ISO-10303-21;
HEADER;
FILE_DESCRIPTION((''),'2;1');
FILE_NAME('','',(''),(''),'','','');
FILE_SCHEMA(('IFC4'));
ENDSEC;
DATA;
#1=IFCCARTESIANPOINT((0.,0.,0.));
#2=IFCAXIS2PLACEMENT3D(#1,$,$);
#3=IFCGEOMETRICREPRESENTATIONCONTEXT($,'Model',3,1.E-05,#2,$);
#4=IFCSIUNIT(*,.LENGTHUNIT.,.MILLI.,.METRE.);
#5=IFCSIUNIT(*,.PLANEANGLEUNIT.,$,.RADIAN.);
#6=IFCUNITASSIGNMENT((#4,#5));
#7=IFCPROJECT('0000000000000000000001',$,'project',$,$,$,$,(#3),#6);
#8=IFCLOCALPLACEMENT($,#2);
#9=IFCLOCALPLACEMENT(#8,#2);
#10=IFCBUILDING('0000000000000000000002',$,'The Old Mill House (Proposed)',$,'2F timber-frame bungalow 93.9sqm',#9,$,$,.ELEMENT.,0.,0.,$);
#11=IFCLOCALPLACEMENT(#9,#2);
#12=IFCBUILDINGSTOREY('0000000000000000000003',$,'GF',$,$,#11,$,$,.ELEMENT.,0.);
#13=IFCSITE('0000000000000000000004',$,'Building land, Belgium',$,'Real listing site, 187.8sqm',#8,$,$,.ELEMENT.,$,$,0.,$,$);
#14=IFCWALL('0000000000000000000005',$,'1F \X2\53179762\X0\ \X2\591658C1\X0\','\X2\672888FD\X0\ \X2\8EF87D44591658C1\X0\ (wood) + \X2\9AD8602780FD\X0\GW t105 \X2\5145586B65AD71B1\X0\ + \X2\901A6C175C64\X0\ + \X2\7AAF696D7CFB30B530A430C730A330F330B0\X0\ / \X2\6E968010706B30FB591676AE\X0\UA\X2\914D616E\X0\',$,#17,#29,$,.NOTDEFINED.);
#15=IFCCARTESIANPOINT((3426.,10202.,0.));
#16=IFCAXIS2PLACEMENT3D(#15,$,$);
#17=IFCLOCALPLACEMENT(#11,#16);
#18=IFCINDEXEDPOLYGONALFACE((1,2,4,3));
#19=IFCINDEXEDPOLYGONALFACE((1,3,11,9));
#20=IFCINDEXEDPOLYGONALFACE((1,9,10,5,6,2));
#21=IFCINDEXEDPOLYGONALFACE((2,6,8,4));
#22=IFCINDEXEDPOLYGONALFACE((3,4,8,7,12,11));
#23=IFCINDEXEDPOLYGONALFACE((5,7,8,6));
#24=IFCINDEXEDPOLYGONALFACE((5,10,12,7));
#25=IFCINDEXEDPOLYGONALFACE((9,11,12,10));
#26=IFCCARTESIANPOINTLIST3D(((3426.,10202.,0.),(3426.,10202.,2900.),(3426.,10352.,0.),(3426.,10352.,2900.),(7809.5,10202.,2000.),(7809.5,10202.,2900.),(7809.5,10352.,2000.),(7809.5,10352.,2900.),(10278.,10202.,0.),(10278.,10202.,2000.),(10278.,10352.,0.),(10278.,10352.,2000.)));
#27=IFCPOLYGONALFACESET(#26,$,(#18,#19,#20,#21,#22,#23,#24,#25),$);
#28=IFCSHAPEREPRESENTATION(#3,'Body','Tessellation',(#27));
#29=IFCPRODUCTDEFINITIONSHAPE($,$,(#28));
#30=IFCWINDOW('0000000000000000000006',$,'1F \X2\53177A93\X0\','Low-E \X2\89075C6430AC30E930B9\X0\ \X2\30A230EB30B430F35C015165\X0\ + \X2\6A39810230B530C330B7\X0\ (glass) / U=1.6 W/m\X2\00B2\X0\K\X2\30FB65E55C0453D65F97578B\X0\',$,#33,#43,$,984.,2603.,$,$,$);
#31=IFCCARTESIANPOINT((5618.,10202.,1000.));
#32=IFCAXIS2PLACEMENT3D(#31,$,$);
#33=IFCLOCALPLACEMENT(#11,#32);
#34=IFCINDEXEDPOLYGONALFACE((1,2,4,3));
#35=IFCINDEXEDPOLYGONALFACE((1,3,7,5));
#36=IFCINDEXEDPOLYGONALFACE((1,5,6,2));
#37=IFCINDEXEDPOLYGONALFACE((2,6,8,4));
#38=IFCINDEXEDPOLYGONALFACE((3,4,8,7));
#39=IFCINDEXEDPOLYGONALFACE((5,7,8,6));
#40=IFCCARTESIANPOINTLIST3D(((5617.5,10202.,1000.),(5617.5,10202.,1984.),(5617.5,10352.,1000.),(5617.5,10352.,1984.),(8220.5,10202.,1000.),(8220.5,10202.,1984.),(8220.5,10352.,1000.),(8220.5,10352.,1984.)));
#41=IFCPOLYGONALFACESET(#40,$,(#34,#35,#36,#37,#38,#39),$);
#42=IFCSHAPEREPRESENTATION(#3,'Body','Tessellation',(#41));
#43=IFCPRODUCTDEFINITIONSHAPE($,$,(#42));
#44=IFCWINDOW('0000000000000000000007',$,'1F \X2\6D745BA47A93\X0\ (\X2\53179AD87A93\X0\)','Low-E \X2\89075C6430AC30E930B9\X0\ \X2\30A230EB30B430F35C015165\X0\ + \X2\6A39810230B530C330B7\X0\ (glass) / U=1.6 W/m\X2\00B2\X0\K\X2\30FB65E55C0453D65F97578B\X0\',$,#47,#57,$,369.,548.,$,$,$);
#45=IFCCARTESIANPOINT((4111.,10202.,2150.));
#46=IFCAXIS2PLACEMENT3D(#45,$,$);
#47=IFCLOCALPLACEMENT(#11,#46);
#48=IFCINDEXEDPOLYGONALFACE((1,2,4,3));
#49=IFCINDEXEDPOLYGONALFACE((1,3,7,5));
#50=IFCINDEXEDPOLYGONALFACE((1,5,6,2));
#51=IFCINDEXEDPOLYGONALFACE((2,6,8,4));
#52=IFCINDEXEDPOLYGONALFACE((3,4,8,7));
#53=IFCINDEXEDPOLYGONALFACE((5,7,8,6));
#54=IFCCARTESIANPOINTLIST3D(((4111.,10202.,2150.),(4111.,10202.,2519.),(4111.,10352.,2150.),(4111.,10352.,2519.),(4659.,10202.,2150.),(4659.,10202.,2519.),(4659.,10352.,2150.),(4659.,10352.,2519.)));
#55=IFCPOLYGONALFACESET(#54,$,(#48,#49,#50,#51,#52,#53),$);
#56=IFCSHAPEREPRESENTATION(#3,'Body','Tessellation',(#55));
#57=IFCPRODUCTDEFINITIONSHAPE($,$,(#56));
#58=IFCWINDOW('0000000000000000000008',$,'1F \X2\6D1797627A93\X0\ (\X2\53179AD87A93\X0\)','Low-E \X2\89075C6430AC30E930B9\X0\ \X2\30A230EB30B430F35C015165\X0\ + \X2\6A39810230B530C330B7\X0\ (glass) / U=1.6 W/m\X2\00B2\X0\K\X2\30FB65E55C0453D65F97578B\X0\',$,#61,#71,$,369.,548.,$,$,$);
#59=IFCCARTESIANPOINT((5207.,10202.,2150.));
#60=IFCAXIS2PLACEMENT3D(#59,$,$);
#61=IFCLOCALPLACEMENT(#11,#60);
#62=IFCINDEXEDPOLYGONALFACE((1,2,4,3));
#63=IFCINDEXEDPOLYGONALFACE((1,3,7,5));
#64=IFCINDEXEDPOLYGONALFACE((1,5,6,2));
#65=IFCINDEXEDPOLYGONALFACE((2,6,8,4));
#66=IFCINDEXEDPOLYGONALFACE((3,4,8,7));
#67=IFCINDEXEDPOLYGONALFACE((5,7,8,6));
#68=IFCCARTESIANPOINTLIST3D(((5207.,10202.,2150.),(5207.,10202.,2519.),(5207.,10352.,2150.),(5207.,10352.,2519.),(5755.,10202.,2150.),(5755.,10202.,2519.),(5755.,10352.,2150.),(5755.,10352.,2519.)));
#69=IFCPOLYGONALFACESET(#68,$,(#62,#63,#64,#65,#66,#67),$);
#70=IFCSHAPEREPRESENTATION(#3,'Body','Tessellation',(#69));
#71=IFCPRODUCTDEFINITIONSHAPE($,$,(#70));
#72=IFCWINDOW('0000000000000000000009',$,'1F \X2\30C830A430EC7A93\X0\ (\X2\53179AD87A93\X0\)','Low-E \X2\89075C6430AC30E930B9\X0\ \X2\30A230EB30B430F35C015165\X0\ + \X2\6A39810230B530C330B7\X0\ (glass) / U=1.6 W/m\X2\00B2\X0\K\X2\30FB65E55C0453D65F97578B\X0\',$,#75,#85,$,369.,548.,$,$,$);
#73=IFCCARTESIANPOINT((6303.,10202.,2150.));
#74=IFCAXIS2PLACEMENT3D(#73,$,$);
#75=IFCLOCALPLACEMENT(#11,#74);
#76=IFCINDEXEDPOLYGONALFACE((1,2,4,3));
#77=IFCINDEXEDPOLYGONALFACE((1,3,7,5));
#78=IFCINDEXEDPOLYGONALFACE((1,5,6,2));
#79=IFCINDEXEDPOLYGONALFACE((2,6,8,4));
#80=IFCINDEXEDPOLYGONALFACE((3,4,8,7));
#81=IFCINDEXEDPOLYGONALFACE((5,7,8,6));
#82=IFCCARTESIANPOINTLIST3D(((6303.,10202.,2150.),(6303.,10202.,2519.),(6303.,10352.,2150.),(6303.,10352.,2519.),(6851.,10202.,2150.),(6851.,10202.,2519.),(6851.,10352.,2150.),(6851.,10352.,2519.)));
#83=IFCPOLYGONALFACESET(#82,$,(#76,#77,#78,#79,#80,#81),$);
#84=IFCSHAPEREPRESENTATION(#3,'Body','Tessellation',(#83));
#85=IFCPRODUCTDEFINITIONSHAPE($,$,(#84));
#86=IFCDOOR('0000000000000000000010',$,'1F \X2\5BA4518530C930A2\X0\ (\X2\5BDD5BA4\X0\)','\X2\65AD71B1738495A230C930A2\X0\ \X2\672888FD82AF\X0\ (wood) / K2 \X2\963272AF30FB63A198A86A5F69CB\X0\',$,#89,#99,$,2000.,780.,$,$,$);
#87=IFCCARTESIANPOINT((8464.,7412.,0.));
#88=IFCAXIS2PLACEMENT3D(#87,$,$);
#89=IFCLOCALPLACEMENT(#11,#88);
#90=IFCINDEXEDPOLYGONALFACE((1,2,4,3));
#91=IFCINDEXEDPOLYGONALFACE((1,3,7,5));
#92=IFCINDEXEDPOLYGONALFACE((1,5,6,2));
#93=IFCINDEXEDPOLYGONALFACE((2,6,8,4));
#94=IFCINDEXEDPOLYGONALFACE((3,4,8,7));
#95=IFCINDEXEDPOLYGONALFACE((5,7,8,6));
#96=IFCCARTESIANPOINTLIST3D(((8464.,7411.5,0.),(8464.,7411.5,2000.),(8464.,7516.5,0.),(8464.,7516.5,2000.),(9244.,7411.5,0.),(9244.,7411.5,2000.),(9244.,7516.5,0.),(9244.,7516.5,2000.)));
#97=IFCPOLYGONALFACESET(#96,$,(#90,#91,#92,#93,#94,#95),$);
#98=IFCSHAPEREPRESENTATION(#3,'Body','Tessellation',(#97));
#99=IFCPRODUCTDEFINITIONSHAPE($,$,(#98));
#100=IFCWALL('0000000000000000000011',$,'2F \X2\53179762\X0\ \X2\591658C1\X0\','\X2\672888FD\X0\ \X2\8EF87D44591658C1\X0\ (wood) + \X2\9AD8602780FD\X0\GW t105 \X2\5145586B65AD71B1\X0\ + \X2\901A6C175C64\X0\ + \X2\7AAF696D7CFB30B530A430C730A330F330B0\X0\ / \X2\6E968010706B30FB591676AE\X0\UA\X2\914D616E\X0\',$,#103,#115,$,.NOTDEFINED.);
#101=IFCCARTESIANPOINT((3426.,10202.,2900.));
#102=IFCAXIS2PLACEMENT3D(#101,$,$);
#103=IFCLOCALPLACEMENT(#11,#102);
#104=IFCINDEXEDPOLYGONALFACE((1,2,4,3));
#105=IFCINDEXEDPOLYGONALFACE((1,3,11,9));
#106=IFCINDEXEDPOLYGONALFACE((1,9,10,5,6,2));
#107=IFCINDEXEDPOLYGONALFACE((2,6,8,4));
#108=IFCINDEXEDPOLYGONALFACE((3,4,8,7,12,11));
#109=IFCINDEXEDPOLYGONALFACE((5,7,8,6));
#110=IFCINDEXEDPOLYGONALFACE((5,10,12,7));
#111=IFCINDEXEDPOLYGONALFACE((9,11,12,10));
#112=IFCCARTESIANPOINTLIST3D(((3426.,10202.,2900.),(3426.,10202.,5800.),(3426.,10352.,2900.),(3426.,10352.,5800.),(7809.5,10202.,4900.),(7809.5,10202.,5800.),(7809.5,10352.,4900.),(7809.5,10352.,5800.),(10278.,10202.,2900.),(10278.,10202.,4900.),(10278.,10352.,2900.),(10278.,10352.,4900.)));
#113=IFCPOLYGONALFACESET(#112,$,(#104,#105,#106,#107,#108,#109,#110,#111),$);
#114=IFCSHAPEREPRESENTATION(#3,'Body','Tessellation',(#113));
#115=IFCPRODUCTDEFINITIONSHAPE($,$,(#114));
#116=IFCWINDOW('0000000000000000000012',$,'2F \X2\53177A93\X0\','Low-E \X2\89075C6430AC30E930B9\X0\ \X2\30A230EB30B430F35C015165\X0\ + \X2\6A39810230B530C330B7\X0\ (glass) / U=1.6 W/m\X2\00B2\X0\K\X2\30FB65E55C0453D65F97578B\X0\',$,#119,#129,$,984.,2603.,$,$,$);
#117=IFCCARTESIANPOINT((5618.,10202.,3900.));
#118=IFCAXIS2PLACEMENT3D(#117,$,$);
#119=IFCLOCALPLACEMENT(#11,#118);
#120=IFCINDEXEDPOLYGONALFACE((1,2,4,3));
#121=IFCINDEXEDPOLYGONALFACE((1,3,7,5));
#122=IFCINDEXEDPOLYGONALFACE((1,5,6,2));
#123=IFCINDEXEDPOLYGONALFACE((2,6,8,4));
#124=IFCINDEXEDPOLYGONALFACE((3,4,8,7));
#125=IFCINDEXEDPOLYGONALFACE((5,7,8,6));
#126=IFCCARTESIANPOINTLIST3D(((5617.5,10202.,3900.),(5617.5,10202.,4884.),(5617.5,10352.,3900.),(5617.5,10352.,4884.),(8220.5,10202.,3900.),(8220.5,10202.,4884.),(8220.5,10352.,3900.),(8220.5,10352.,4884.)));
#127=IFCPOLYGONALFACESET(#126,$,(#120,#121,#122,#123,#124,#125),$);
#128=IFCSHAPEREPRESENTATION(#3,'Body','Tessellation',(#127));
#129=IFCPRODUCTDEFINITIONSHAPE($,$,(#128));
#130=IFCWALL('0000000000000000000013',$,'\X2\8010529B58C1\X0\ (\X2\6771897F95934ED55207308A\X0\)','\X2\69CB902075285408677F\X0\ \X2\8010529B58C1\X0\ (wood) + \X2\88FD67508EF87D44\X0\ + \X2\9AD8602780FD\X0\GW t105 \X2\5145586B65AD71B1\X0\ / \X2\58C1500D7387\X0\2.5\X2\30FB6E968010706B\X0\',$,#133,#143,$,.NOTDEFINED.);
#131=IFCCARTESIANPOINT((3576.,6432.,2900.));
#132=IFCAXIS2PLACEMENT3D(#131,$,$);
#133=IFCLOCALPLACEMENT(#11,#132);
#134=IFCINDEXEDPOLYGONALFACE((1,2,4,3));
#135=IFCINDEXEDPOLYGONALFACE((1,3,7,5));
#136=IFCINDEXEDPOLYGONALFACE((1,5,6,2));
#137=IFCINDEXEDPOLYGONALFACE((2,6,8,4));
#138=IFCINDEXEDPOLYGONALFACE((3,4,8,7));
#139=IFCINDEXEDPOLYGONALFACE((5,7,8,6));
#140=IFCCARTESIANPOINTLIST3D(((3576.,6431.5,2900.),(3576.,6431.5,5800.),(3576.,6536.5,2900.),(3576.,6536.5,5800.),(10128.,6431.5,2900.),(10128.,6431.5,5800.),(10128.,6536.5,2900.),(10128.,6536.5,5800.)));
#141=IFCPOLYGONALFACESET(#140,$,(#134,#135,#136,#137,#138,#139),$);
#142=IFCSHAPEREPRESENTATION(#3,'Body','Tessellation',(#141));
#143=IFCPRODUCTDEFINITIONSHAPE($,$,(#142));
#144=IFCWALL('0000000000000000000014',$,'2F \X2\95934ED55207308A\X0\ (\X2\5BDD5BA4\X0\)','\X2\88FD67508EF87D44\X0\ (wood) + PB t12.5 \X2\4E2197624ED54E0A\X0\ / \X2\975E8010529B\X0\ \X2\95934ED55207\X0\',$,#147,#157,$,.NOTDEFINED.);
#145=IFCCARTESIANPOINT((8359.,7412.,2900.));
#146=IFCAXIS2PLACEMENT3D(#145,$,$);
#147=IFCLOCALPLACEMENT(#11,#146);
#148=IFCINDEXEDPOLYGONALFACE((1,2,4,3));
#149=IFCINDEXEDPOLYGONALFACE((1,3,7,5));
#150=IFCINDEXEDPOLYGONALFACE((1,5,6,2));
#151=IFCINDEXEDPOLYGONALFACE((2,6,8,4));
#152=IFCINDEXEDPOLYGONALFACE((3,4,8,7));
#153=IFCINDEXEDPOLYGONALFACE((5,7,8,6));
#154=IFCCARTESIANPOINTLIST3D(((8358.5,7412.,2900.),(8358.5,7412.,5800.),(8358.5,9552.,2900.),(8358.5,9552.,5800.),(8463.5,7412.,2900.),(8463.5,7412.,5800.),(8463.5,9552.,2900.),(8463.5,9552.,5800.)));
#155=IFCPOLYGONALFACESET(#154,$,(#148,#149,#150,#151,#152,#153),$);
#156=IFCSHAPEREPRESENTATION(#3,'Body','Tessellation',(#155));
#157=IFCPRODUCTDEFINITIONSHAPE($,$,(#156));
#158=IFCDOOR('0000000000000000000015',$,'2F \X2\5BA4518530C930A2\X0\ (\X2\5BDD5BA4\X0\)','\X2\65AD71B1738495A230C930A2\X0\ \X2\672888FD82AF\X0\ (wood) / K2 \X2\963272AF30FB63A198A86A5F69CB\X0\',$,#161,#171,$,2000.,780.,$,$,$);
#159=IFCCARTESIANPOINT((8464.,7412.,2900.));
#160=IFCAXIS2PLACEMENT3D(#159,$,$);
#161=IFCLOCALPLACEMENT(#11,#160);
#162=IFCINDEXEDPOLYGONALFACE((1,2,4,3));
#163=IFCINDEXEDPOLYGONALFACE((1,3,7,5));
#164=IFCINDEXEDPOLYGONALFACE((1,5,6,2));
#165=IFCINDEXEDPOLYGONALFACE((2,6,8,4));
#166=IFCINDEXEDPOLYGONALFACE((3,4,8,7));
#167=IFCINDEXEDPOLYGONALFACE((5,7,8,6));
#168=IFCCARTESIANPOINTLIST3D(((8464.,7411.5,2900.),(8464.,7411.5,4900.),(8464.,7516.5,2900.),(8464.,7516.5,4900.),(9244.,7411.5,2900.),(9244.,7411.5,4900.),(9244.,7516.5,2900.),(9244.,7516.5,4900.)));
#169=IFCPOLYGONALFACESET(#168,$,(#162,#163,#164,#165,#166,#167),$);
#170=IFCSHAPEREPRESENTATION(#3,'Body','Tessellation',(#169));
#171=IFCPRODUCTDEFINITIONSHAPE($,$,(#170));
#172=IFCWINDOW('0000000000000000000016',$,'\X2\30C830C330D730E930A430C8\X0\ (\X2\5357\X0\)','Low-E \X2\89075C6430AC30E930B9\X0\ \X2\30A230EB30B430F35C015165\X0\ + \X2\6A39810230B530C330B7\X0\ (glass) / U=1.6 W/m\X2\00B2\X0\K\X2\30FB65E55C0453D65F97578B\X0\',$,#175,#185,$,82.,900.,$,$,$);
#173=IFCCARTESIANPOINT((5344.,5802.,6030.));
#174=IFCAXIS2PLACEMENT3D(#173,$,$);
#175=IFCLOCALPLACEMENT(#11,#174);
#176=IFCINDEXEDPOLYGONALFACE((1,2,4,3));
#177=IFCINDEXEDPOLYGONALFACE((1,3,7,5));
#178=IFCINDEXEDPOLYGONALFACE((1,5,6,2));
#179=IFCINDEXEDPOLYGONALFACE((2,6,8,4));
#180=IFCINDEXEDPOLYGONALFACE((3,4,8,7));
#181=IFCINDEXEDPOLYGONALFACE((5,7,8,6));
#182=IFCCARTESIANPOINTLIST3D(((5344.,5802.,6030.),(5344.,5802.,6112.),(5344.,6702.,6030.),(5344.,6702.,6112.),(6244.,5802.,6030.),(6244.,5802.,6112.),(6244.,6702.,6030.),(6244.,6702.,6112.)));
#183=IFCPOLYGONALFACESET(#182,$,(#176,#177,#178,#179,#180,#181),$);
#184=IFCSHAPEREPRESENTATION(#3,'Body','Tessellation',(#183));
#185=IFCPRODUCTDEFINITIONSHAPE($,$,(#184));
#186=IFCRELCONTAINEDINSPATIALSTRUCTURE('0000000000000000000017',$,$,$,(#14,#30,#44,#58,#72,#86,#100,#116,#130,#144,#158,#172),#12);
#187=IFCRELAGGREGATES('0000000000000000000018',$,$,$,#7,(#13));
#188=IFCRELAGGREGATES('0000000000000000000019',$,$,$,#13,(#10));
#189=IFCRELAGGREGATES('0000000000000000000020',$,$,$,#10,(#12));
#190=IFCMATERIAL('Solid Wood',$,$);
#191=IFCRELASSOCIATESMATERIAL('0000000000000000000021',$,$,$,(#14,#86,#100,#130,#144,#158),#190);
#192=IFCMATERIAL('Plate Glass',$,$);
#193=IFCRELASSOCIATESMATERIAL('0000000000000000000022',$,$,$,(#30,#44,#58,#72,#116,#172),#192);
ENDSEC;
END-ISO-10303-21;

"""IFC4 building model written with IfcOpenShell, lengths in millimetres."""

from ifc_helpers import new_model, si_unit, frame, frame_2d, origin, place, context, project, spatial, rectangle, extrude, material, element, fill, save


model = new_model("IFC4")

# Units and contexts
model_context = context("Model", 3, precision=1e-05, world=origin())
ifc_project = project(units=[si_unit("LENGTHUNIT", "METRE", prefix="MILLI"), si_unit("PLANEANGLEUNIT", "RADIAN")], contexts=[model_context])

# Site, building, storey
site_placement = place(None, origin())
site = spatial("IfcSite", under=ifc_project, at=site_placement, Name="Building land, Belgium", ObjectType="Real listing site, 187.8sqm", CompositionType="ELEMENT", RefElevation=0.0)
building_placement = place(site_placement, origin())
building = spatial("IfcBuilding", under=site, at=building_placement, Name="The Old Mill House (Proposed)", ObjectType="2F timber-frame bungalow 93.9sqm", CompositionType="ELEMENT", ElevationOfRefHeight=0.0, ElevationOfTerrain=0.0)
storey_placement = place(building_placement, origin())
storey = spatial("IfcBuildingStorey", under=building, at=storey_placement, Name="GF", CompositionType="ELEMENT", Elevation=0.0)

# Wall, openings, windows
ifc_material_1 = material(Name="Solid Wood")
wall_1_placement = place(storey_placement, frame((3426.0, 10202.0, 0.0)))
wall_1 = element("IfcWall", 1, at=wall_1_placement, inside=storey, material=ifc_material_1, Name="1F 北面 外壁", Description="木製 軸組外壁 (wood) + 高性能GW t105 充填断熱 + 通気層 + 窯業系サイディング / 準耐火・外皮UA配慮", PredefinedType="NOTDEFINED", context=model_context, shape_type="SweptSolid", body=[
    extrude(rectangle(XDim=6852.0, YDim=150.0, at=frame_2d((3426.0, 75.0))), frame((3426.0, 10202.0, 0.0)), (0.0, 0.0, 1.0), 2900.0),
])
opening_1_placement = place(storey_placement, frame((5618.0, 10202.0, 1000.0)))
opening_1 = element("IfcOpeningElement", 2, at=opening_1_placement, cuts=wall_1, PredefinedType="NOTDEFINED", context=model_context, shape_type="SweptSolid", body=[
    extrude(rectangle(XDim=2603.0, YDim=150.0, at=frame_2d((1301.0, 75.0))), frame((5618.0, 10202.0, 1000.0)), (0.0, 0.0, 1.0), 984.0),
])
opening_2_placement = place(storey_placement, frame((4111.0, 10202.0, 2150.0)))
opening_2 = element("IfcOpeningElement", 3, at=opening_2_placement, cuts=wall_1, PredefinedType="NOTDEFINED", context=model_context, shape_type="SweptSolid", body=[
    extrude(rectangle(XDim=548.0, YDim=150.0, at=frame_2d((274.0, 75.0))), frame((4111.0, 10202.0, 2150.0)), (0.0, 0.0, 1.0), 369.0),
])
opening_3_placement = place(storey_placement, frame((5207.0, 10202.0, 2150.0)))
opening_3 = element("IfcOpeningElement", 4, at=opening_3_placement, cuts=wall_1, PredefinedType="NOTDEFINED", context=model_context, shape_type="SweptSolid", body=[
    extrude(rectangle(XDim=548.0, YDim=150.0, at=frame_2d((274.0, 75.0))), frame((5207.0, 10202.0, 2150.0)), (0.0, 0.0, 1.0), 369.0),
])
opening_4_placement = place(storey_placement, frame((6303.0, 10202.0, 2150.0)))
opening_4 = element("IfcOpeningElement", 5, at=opening_4_placement, cuts=wall_1, PredefinedType="NOTDEFINED", context=model_context, shape_type="SweptSolid", body=[
    extrude(rectangle(XDim=548.0, YDim=150.0, at=frame_2d((274.0, 75.0))), frame((6303.0, 10202.0, 2150.0)), (0.0, 0.0, 1.0), 369.0),
])
ifc_material_2 = material(Name="Plate Glass")
window_1_placement = place(storey_placement, frame((5618.0, 10202.0, 1000.0)))
window_1 = element("IfcWindow", 6, at=window_1_placement, inside=storey, material=ifc_material_2, Name="1F 北窓", Description="Low-E 複層ガラス アルゴン封入 + 樹脂サッシ (glass) / U=1.6 W/m²K・日射取得型", OverallHeight=984.0, OverallWidth=2603.0, context=model_context, shape_type="SweptSolid", body=[
    extrude(rectangle(XDim=2603.0, YDim=150.0, at=frame_2d((1301.0, 75.0))), frame((5618.0, 10202.0, 1000.0)), (0.0, 0.0, 1.0), 984.0),
])
fill(opening_1, window_1)
window_2_placement = place(storey_placement, frame((4111.0, 10202.0, 2150.0)))
window_2 = element("IfcWindow", 7, at=window_2_placement, inside=storey, material=ifc_material_2, Name="1F 浴室窓 (北高窓)", Description="Low-E 複層ガラス アルゴン封入 + 樹脂サッシ (glass) / U=1.6 W/m²K・日射取得型", OverallHeight=369.0, OverallWidth=548.0, context=model_context, shape_type="SweptSolid", body=[
    extrude(rectangle(XDim=548.0, YDim=150.0, at=frame_2d((274.0, 75.0))), frame((4111.0, 10202.0, 2150.0)), (0.0, 0.0, 1.0), 369.0),
])
fill(opening_2, window_2)
window_3_placement = place(storey_placement, frame((5207.0, 10202.0, 2150.0)))
window_3 = element("IfcWindow", 8, at=window_3_placement, inside=storey, material=ifc_material_2, Name="1F 洗面窓 (北高窓)", Description="Low-E 複層ガラス アルゴン封入 + 樹脂サッシ (glass) / U=1.6 W/m²K・日射取得型", OverallHeight=369.0, OverallWidth=548.0, context=model_context, shape_type="SweptSolid", body=[
    extrude(rectangle(XDim=548.0, YDim=150.0, at=frame_2d((274.0, 75.0))), frame((5207.0, 10202.0, 2150.0)), (0.0, 0.0, 1.0), 369.0),
])
fill(opening_3, window_3)
window_4_placement = place(storey_placement, frame((6303.0, 10202.0, 2150.0)))
window_4 = element("IfcWindow", 9, at=window_4_placement, inside=storey, material=ifc_material_2, Name="1F トイレ窓 (北高窓)", Description="Low-E 複層ガラス アルゴン封入 + 樹脂サッシ (glass) / U=1.6 W/m²K・日射取得型", OverallHeight=369.0, OverallWidth=548.0, context=model_context, shape_type="SweptSolid", body=[
    extrude(rectangle(XDim=548.0, YDim=150.0, at=frame_2d((274.0, 75.0))), frame((6303.0, 10202.0, 2150.0)), (0.0, 0.0, 1.0), 369.0),
])
fill(opening_4, window_4)

# Door
door_1_placement = place(storey_placement, frame((8464.0, 7412.0, 0.0)))
element("IfcDoor", 10, at=door_1_placement, inside=storey, material=ifc_material_1, Name="1F 室内ドア (寝室)", Description="断熱玄関ドア 木製芯 (wood) / K2 防犯・採風機構", OverallHeight=2000.0, OverallWidth=780.0, context=model_context, shape_type="SweptSolid", body=[
    extrude(rectangle(XDim=780.0, YDim=105.0, at=frame_2d((390.0, 52.0))), frame((8464.0, 7412.0, 0.0)), (0.0, 0.0, 1.0), 2000.0),
])

# Wall, opening, window
wall_2_placement = place(storey_placement, frame((3426.0, 10202.0, 2900.0)))
wall_2 = element("IfcWall", 11, at=wall_2_placement, inside=storey, material=ifc_material_1, Name="2F 北面 外壁", Description="木製 軸組外壁 (wood) + 高性能GW t105 充填断熱 + 通気層 + 窯業系サイディング / 準耐火・外皮UA配慮", PredefinedType="NOTDEFINED", context=model_context, shape_type="SweptSolid", body=[
    extrude(rectangle(XDim=6852.0, YDim=150.0, at=frame_2d((3426.0, 75.0))), frame((3426.0, 10202.0, 2900.0)), (0.0, 0.0, 1.0), 2900.0),
])
opening_5_placement = place(storey_placement, frame((5618.0, 10202.0, 3900.0)))
opening_5 = element("IfcOpeningElement", 12, at=opening_5_placement, cuts=wall_2, PredefinedType="NOTDEFINED", context=model_context, shape_type="SweptSolid", body=[
    extrude(rectangle(XDim=2603.0, YDim=150.0, at=frame_2d((1301.0, 75.0))), frame((5618.0, 10202.0, 3900.0)), (0.0, 0.0, 1.0), 984.0),
])
window_5_placement = place(storey_placement, frame((5618.0, 10202.0, 3900.0)))
window_5 = element("IfcWindow", 13, at=window_5_placement, inside=storey, material=ifc_material_2, Name="2F 北窓", Description="Low-E 複層ガラス アルゴン封入 + 樹脂サッシ (glass) / U=1.6 W/m²K・日射取得型", OverallHeight=984.0, OverallWidth=2603.0, context=model_context, shape_type="SweptSolid", body=[
    extrude(rectangle(XDim=2603.0, YDim=150.0, at=frame_2d((1301.0, 75.0))), frame((5618.0, 10202.0, 3900.0)), (0.0, 0.0, 1.0), 984.0),
])
fill(opening_5, window_5)

# Walls
wall_3_placement = place(storey_placement, frame((3576.0, 6432.0, 2900.0)))
element("IfcWall", 14, at=wall_3_placement, inside=storey, material=ifc_material_1, Name="耐力壁 (東西間仕切り)", Description="構造用合板 耐力壁 (wood) + 製材軸組 + 高性能GW t105 充填断熱 / 壁倍率2.5・準耐火", PredefinedType="NOTDEFINED", context=model_context, shape_type="SweptSolid", body=[
    extrude(rectangle(XDim=6552.0, YDim=105.0, at=frame_2d((3276.0, 52.0))), frame((3576.0, 6432.0, 2900.0)), (0.0, 0.0, 1.0), 2900.0),
])
wall_4_placement = place(storey_placement, frame((8359.0, 7412.0, 2900.0)))
element("IfcWall", 15, at=wall_4_placement, inside=storey, material=ifc_material_1, Name="2F 間仕切り (寝室)", Description="製材軸組 (wood) + PB t12.5 両面仕上 / 非耐力 間仕切", PredefinedType="NOTDEFINED", context=model_context, shape_type="SweptSolid", body=[
    extrude(rectangle(XDim=105.0, YDim=2140.0, at=frame_2d((52.0, 1070.0))), frame((8359.0, 7412.0, 2900.0)), (0.0, 0.0, 1.0), 2900.0),
])

# Door
door_2_placement = place(storey_placement, frame((8464.0, 7412.0, 2900.0)))
element("IfcDoor", 16, at=door_2_placement, inside=storey, material=ifc_material_1, Name="2F 室内ドア (寝室)", Description="断熱玄関ドア 木製芯 (wood) / K2 防犯・採風機構", OverallHeight=2000.0, OverallWidth=780.0, context=model_context, shape_type="SweptSolid", body=[
    extrude(rectangle(XDim=780.0, YDim=105.0, at=frame_2d((390.0, 52.0))), frame((8464.0, 7412.0, 2900.0)), (0.0, 0.0, 1.0), 2000.0),
])

# Window
window_6_placement = place(storey_placement, frame((5344.0, 5802.0, 6030.0)))
element("IfcWindow", 17, at=window_6_placement, inside=storey, material=ifc_material_2, Name="トップライト (南)", Description="Low-E 複層ガラス アルゴン封入 + 樹脂サッシ (glass) / U=1.6 W/m²K・日射取得型", OverallHeight=82.0, OverallWidth=900.0, context=model_context, shape_type="SweptSolid", body=[
    extrude(rectangle(XDim=900.0, YDim=900.0, at=frame_2d((450.0, 450.0))), frame((5344.0, 5802.0, 6030.0)), (0.0, 0.0, 1.0), 82.0),
])

save(model, "model.ifc")
